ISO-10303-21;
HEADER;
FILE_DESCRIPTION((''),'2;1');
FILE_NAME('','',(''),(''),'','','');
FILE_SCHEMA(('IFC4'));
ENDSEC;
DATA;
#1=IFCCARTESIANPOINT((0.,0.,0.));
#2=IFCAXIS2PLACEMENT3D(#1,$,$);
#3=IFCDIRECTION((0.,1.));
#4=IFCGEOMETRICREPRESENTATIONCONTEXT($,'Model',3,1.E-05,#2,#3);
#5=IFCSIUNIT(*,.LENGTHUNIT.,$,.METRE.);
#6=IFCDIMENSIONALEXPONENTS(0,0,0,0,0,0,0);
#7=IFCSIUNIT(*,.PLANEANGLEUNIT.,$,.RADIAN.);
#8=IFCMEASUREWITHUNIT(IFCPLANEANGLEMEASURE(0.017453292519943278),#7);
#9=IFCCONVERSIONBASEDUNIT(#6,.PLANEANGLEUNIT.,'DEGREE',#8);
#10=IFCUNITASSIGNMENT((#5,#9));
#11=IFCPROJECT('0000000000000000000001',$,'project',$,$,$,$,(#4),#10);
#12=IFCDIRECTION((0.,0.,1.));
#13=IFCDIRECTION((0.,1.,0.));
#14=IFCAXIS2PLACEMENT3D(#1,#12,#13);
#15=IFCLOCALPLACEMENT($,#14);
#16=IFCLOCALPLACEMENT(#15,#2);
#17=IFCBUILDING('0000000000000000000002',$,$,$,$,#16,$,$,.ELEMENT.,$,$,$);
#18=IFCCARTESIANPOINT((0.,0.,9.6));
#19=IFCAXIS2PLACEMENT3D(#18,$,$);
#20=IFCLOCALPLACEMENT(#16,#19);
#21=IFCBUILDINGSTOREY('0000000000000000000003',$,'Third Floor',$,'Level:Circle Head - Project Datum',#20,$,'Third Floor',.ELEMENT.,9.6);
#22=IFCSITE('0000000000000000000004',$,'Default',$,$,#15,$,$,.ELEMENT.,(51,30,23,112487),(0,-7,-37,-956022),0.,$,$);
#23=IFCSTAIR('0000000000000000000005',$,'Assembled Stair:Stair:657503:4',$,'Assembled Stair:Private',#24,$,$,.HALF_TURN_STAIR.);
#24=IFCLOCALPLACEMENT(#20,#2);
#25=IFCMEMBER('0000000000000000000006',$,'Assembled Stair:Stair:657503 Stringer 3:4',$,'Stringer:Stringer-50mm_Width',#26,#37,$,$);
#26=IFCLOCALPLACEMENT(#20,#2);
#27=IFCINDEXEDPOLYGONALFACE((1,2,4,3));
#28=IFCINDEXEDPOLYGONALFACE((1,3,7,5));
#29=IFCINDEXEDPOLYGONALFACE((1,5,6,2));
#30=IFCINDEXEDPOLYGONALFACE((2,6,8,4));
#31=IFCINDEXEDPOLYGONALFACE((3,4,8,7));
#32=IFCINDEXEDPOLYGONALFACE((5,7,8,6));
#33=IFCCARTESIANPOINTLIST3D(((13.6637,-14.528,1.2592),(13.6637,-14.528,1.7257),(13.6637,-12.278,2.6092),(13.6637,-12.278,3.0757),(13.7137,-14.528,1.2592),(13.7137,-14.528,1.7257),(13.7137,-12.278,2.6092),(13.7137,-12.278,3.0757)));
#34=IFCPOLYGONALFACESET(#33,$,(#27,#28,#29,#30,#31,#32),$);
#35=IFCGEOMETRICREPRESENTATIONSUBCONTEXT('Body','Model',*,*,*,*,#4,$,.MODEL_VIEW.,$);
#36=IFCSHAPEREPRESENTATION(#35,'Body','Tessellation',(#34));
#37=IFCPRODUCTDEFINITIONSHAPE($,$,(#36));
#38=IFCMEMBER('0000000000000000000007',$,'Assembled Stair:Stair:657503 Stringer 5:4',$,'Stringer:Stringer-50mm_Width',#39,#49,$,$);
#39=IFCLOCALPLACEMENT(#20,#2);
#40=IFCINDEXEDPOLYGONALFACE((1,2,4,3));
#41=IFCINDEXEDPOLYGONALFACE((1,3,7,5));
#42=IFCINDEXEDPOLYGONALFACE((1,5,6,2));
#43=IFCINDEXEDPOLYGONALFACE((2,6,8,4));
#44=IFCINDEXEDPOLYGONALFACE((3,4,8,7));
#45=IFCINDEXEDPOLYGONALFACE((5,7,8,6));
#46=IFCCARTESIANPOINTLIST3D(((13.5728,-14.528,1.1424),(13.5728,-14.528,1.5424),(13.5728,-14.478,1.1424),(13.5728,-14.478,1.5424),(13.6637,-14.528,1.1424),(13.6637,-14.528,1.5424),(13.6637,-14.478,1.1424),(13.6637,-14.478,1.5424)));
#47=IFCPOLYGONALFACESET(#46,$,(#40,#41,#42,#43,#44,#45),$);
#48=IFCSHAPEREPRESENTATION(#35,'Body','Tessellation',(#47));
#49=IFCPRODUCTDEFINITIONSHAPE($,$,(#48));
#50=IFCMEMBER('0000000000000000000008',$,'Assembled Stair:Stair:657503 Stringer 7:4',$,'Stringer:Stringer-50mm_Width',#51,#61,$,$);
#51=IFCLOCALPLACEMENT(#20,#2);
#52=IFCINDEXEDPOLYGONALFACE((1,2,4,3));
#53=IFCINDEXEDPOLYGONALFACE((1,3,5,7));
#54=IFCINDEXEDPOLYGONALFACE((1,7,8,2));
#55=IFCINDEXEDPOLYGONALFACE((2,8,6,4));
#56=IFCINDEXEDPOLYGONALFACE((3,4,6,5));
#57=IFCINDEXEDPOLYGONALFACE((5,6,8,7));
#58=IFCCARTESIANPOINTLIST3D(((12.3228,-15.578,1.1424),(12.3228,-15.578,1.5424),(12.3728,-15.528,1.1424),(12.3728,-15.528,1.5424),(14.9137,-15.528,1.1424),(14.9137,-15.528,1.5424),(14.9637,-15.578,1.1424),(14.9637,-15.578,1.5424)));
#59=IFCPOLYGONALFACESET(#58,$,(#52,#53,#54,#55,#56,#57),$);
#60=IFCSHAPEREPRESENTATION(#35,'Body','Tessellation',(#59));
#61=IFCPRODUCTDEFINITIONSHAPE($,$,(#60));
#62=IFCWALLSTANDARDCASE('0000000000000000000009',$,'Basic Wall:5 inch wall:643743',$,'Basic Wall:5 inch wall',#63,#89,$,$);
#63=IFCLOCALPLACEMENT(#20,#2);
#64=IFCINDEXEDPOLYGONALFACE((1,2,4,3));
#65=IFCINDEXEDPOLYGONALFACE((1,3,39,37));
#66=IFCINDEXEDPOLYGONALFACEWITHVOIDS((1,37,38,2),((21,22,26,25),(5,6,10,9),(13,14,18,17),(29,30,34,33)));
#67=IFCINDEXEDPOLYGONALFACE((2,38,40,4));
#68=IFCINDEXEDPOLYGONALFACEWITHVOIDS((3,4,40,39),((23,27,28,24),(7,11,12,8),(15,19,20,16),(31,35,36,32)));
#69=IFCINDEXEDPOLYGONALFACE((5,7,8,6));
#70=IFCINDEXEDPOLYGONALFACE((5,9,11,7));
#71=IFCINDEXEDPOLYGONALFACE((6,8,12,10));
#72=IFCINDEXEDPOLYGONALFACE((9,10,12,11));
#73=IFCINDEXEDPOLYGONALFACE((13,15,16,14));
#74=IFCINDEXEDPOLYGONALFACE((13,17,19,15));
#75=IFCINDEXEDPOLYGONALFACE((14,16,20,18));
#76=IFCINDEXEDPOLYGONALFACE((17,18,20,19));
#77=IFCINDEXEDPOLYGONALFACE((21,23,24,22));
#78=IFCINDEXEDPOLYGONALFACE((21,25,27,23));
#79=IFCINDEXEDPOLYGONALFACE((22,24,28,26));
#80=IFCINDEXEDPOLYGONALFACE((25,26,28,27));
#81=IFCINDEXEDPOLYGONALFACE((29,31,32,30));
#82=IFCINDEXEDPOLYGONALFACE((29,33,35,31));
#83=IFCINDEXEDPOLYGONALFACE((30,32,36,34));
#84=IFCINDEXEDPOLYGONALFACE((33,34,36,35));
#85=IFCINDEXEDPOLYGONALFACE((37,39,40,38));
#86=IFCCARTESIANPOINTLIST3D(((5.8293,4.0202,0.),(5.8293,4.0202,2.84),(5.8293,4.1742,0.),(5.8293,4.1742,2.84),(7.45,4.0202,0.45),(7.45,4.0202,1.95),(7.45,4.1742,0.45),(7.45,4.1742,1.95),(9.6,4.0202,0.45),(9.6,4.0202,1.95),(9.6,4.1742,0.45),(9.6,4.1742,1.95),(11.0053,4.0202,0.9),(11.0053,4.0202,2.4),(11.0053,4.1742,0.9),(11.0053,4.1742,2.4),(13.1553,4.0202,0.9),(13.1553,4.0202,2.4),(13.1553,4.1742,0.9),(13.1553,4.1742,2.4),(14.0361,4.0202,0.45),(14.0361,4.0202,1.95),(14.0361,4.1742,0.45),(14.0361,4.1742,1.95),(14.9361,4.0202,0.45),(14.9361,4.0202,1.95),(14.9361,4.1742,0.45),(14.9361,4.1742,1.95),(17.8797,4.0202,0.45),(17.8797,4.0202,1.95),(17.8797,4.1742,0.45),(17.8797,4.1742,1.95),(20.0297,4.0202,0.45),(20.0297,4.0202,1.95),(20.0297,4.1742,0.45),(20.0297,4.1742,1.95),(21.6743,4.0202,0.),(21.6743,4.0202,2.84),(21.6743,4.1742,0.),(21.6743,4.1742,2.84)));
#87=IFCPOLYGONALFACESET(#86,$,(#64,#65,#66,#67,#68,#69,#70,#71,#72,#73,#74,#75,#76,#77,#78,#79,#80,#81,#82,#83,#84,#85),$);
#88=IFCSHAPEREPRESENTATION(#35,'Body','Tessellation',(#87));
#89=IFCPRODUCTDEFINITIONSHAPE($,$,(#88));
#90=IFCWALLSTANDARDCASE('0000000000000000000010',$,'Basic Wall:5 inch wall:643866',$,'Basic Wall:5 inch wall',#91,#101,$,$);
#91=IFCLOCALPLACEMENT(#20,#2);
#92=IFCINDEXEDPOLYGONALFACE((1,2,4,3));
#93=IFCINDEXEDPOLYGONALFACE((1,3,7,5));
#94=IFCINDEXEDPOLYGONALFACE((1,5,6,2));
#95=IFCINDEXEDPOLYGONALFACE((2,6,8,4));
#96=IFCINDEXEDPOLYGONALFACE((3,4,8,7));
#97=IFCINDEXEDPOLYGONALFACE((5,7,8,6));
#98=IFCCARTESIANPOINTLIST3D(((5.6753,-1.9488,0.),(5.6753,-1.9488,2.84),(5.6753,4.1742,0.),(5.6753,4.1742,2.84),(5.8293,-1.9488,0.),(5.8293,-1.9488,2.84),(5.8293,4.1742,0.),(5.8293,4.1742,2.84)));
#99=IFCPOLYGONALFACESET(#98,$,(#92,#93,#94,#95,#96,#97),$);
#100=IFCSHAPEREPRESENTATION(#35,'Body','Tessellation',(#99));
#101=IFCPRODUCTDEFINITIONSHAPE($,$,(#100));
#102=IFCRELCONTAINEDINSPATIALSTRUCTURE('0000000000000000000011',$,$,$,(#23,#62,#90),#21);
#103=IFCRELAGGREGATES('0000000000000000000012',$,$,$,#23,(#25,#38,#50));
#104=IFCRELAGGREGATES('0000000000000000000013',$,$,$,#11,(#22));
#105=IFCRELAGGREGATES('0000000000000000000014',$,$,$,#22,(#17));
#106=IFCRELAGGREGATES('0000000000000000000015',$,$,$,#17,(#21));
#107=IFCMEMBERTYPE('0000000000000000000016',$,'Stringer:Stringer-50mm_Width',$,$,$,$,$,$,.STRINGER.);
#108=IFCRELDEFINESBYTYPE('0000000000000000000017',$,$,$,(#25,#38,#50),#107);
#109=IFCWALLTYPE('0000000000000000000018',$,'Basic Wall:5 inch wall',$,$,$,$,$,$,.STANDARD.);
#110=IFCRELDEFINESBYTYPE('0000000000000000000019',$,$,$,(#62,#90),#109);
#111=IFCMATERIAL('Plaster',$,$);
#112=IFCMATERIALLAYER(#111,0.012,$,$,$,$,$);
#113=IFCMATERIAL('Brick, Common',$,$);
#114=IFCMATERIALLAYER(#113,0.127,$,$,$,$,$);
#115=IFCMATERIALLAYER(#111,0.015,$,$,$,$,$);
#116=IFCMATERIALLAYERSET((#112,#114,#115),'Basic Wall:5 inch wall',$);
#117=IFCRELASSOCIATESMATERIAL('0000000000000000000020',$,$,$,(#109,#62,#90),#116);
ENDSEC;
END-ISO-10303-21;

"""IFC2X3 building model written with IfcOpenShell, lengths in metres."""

from ifc_helpers import new_model, entity, si_unit, converted_unit, direction, frame, frame_2d, origin, place, context, subcontext, project, spatial, polyline, rectangle, outline, extrude, material, layer, layer_set, layer_usage, type_object, element, aggregate, save


model = new_model("IFC2X3")

# Units and contexts
model_context = context("Model", 3, precision=1e-05, world=origin(), true_north=direction((0.0, 1.0)))
body_context = subcontext(model_context, "Body", "Model", "MODEL_VIEW")
ifc_project = project(units=[si_unit("LENGTHUNIT", "METRE"), converted_unit("PLANEANGLEUNIT", "DEGREE", entity("IfcPlaneAngleMeasure", 0.017453292519943278), si_unit("PLANEANGLEUNIT", "RADIAN"), dimensions=[0, 0, 0, 0, 0, 0, 0])], contexts=[model_context])

# Site, building, storey
site_placement = place(None, frame((0.0, 0.0, 0.0), z_axis=(0.0, 0.0, 1.0), x_axis=(0.0, 1.0, 0.0)))
site = spatial("IfcSite", under=ifc_project, at=site_placement, Name="Default", CompositionType="ELEMENT", RefLatitude=(51, 30, 23, 112487), RefLongitude=(0, -7, -37, -956022), RefElevation=0.0)
building_placement = place(site_placement, origin())
building = spatial("IfcBuilding", under=site, at=building_placement, CompositionType="ELEMENT")
storey_placement = place(building_placement, frame((0.0, 0.0, 9.6)))
storey = spatial("IfcBuildingStorey", under=building, at=storey_placement, Name="Third Floor", ObjectType="Level:Circle Head - Project Datum", LongName="Third Floor", CompositionType="ELEMENT", Elevation=9.6)

# Stair, members
stair_placement = place(storey_placement, origin())
stair = element("IfcStair", 1, at=stair_placement, inside=storey, Name="Assembled Stair:Stair:657503:4", ObjectType="Assembled Stair:Private", ShapeType="HALF_TURN_STAIR")
member_type = type_object("IfcMemberType", Name="Stringer:Stringer-50mm_Width", PredefinedType="STRINGER")
member_1_placement = place(stair_placement, origin())
member_1 = element("IfcMember", 2, at=member_1_placement, type_object=member_type, Name="Assembled Stair:Stair:657503 Stringer 3:4", ObjectType="Stringer:Stringer-50mm_Width", context=body_context, shape_type="SweptSolid", body=[
    extrude(outline(polyline([(-1.432, -0.2), (1.192, -0.2), (1.432, 0.2), (-1.192, 0.2), (-1.432, -0.2)])), frame((13.6637, -13.403, 2.1675), z_axis=(1.0, 0.0, 0.0), x_axis=(0.0, 0.857493, 0.514496)), (0.0, 0.0, 1.0), 0.05),
])
member_2_placement = place(stair_placement, origin())
member_2 = element("IfcMember", 3, at=member_2_placement, type_object=member_type, Name="Assembled Stair:Stair:657503 Stringer 5:4", ObjectType="Stringer:Stringer-50mm_Width", context=body_context, shape_type="SweptSolid", body=[
    extrude(rectangle(XDim=0.0908, YDim=0.05, at=frame_2d((0.0, 0.0), x_axis=(1.0, 0.0))), frame((13.6183, -14.503, 1.1424), z_axis=(0.0, 0.0, 1.0), x_axis=(-1.0, 0.0, 0.0)), (0.0, 0.0, 1.0), 0.4),
])
member_3_placement = place(stair_placement, origin())
member_3 = element("IfcMember", 4, at=member_3_placement, type_object=member_type, Name="Assembled Stair:Stair:657503 Stringer 7:4", ObjectType="Stringer:Stringer-50mm_Width", context=body_context, shape_type="SweptSolid", body=[
    extrude(outline(polyline([(-1.3204, -0.025), (1.3204, -0.025), (1.2704, 0.025), (-1.2704, 0.025), (-1.3204, -0.025)])), frame((13.6433, -15.553, 1.1424)), (0.0, 0.0, 1.0), 0.4),
])

# Wall, openings
ifc_material_1 = material(Name="Plaster")
ifc_layer_1 = layer(ifc_material_1, 0.012)
ifc_material_2 = material(Name="Brick, Common")
ifc_layer_2 = layer(ifc_material_2, 0.127)
ifc_layer_3 = layer(ifc_material_1, 0.015)
ifc_layer_set_1 = layer_set([ifc_layer_1, ifc_layer_2, ifc_layer_3], Name="Basic Wall:5 inch wall")
ifc_layer_usage_1 = layer_usage(ifc_layer_set_1, "AXIS2", "NEGATIVE", 0.077)
wall_type = type_object("IfcWallType", Name="Basic Wall:5 inch wall", PredefinedType="STANDARD", material=ifc_layer_set_1)
wall_1_placement = place(storey_placement, frame((5.8293, 4.0972, 0.0)))
wall_1 = element("IfcWallStandardCase", 5, at=wall_1_placement, inside=storey, type_object=wall_type, material=ifc_layer_usage_1, Name="Basic Wall:5 inch wall:643743", ObjectType="Basic Wall:5 inch wall", context=body_context, shape_type="SweptSolid", body=[
    extrude(rectangle(XDim=15.8451, YDim=0.154, at=frame_2d((7.9225, 0.0), x_axis=(-1.0, 0.0))), origin(), (0.0, 0.0, 1.0), 2.84),
])
opening_1_placement = place(wall_1_placement, frame((1.6208, -0.077, 0.45)))
element("IfcOpeningElement", 6, at=opening_1_placement, cuts=wall_1, ObjectType="Opening", context=body_context, shape_type="SweptSolid", body=[
    extrude(rectangle(XDim=1.5, YDim=2.15, at=frame_2d((0.75, 1.075), x_axis=(-1.0, 0.0))), frame((0.0, 0.0, 0.0), z_axis=(0.0, 1.0, 0.0), x_axis=(0.0, 0.0, 1.0)), (0.0, 0.0, 1.0), 0.154),
])
opening_2_placement = place(wall_1_placement, frame((12.0504, -0.077, 0.45)))
element("IfcOpeningElement", 7, at=opening_2_placement, cuts=wall_1, ObjectType="Opening", context=body_context, shape_type="SweptSolid", body=[
    extrude(rectangle(XDim=1.5, YDim=2.15, at=frame_2d((0.75, 1.075), x_axis=(-1.0, 0.0))), frame((0.0, 0.0, 0.0), z_axis=(0.0, 1.0, 0.0), x_axis=(0.0, 0.0, 1.0)), (0.0, 0.0, 1.0), 0.154),
])
opening_3_placement = place(wall_1_placement, frame((9.1069, 0.077, 0.45)))
element("IfcOpeningElement", 8, at=opening_3_placement, cuts=wall_1, ObjectType="Opening", context=body_context, shape_type="SweptSolid", body=[
    extrude(rectangle(XDim=1.5, YDim=0.9, at=frame_2d((0.75, 0.45), x_axis=(-1.0, 0.0))), frame((0.0, 0.0, 0.0), z_axis=(0.0, -1.0, 0.0), x_axis=(0.0, 0.0, 1.0)), (0.0, 0.0, 1.0), 0.154),
])
opening_4_placement = place(wall_1_placement, frame((5.176, -0.077, 0.9)))
element("IfcOpeningElement", 9, at=opening_4_placement, cuts=wall_1, ObjectType="Opening", context=body_context, shape_type="SweptSolid", body=[
    extrude(rectangle(XDim=1.5, YDim=2.15, at=frame_2d((0.75, 1.075), x_axis=(-1.0, 0.0))), frame((0.0, 0.0, 0.0), z_axis=(0.0, 1.0, 0.0), x_axis=(0.0, 0.0, 1.0)), (0.0, 0.0, 1.0), 0.154),
])

# Wall
ifc_layer_usage_2 = layer_usage(ifc_layer_set_1, "AXIS2", "NEGATIVE", 0.077)
wall_2_placement = place(storey_placement, frame((5.7523, 4.1742, 0.0), z_axis=(0.0, 0.0, 1.0), x_axis=(0.0, -1.0, 0.0)))
element("IfcWallStandardCase", 10, at=wall_2_placement, inside=storey, type_object=wall_type, material=ifc_layer_usage_2, Name="Basic Wall:5 inch wall:643866", ObjectType="Basic Wall:5 inch wall", context=body_context, shape_type="SweptSolid", body=[
    extrude(rectangle(XDim=6.123, YDim=0.154, at=frame_2d((3.0615, 0.0), x_axis=(-1.0, 0.0))), origin(), (0.0, 0.0, 1.0), 2.84),
])

aggregate(stair, [member_1, member_2, member_3])

save(model, "model.ifc")
